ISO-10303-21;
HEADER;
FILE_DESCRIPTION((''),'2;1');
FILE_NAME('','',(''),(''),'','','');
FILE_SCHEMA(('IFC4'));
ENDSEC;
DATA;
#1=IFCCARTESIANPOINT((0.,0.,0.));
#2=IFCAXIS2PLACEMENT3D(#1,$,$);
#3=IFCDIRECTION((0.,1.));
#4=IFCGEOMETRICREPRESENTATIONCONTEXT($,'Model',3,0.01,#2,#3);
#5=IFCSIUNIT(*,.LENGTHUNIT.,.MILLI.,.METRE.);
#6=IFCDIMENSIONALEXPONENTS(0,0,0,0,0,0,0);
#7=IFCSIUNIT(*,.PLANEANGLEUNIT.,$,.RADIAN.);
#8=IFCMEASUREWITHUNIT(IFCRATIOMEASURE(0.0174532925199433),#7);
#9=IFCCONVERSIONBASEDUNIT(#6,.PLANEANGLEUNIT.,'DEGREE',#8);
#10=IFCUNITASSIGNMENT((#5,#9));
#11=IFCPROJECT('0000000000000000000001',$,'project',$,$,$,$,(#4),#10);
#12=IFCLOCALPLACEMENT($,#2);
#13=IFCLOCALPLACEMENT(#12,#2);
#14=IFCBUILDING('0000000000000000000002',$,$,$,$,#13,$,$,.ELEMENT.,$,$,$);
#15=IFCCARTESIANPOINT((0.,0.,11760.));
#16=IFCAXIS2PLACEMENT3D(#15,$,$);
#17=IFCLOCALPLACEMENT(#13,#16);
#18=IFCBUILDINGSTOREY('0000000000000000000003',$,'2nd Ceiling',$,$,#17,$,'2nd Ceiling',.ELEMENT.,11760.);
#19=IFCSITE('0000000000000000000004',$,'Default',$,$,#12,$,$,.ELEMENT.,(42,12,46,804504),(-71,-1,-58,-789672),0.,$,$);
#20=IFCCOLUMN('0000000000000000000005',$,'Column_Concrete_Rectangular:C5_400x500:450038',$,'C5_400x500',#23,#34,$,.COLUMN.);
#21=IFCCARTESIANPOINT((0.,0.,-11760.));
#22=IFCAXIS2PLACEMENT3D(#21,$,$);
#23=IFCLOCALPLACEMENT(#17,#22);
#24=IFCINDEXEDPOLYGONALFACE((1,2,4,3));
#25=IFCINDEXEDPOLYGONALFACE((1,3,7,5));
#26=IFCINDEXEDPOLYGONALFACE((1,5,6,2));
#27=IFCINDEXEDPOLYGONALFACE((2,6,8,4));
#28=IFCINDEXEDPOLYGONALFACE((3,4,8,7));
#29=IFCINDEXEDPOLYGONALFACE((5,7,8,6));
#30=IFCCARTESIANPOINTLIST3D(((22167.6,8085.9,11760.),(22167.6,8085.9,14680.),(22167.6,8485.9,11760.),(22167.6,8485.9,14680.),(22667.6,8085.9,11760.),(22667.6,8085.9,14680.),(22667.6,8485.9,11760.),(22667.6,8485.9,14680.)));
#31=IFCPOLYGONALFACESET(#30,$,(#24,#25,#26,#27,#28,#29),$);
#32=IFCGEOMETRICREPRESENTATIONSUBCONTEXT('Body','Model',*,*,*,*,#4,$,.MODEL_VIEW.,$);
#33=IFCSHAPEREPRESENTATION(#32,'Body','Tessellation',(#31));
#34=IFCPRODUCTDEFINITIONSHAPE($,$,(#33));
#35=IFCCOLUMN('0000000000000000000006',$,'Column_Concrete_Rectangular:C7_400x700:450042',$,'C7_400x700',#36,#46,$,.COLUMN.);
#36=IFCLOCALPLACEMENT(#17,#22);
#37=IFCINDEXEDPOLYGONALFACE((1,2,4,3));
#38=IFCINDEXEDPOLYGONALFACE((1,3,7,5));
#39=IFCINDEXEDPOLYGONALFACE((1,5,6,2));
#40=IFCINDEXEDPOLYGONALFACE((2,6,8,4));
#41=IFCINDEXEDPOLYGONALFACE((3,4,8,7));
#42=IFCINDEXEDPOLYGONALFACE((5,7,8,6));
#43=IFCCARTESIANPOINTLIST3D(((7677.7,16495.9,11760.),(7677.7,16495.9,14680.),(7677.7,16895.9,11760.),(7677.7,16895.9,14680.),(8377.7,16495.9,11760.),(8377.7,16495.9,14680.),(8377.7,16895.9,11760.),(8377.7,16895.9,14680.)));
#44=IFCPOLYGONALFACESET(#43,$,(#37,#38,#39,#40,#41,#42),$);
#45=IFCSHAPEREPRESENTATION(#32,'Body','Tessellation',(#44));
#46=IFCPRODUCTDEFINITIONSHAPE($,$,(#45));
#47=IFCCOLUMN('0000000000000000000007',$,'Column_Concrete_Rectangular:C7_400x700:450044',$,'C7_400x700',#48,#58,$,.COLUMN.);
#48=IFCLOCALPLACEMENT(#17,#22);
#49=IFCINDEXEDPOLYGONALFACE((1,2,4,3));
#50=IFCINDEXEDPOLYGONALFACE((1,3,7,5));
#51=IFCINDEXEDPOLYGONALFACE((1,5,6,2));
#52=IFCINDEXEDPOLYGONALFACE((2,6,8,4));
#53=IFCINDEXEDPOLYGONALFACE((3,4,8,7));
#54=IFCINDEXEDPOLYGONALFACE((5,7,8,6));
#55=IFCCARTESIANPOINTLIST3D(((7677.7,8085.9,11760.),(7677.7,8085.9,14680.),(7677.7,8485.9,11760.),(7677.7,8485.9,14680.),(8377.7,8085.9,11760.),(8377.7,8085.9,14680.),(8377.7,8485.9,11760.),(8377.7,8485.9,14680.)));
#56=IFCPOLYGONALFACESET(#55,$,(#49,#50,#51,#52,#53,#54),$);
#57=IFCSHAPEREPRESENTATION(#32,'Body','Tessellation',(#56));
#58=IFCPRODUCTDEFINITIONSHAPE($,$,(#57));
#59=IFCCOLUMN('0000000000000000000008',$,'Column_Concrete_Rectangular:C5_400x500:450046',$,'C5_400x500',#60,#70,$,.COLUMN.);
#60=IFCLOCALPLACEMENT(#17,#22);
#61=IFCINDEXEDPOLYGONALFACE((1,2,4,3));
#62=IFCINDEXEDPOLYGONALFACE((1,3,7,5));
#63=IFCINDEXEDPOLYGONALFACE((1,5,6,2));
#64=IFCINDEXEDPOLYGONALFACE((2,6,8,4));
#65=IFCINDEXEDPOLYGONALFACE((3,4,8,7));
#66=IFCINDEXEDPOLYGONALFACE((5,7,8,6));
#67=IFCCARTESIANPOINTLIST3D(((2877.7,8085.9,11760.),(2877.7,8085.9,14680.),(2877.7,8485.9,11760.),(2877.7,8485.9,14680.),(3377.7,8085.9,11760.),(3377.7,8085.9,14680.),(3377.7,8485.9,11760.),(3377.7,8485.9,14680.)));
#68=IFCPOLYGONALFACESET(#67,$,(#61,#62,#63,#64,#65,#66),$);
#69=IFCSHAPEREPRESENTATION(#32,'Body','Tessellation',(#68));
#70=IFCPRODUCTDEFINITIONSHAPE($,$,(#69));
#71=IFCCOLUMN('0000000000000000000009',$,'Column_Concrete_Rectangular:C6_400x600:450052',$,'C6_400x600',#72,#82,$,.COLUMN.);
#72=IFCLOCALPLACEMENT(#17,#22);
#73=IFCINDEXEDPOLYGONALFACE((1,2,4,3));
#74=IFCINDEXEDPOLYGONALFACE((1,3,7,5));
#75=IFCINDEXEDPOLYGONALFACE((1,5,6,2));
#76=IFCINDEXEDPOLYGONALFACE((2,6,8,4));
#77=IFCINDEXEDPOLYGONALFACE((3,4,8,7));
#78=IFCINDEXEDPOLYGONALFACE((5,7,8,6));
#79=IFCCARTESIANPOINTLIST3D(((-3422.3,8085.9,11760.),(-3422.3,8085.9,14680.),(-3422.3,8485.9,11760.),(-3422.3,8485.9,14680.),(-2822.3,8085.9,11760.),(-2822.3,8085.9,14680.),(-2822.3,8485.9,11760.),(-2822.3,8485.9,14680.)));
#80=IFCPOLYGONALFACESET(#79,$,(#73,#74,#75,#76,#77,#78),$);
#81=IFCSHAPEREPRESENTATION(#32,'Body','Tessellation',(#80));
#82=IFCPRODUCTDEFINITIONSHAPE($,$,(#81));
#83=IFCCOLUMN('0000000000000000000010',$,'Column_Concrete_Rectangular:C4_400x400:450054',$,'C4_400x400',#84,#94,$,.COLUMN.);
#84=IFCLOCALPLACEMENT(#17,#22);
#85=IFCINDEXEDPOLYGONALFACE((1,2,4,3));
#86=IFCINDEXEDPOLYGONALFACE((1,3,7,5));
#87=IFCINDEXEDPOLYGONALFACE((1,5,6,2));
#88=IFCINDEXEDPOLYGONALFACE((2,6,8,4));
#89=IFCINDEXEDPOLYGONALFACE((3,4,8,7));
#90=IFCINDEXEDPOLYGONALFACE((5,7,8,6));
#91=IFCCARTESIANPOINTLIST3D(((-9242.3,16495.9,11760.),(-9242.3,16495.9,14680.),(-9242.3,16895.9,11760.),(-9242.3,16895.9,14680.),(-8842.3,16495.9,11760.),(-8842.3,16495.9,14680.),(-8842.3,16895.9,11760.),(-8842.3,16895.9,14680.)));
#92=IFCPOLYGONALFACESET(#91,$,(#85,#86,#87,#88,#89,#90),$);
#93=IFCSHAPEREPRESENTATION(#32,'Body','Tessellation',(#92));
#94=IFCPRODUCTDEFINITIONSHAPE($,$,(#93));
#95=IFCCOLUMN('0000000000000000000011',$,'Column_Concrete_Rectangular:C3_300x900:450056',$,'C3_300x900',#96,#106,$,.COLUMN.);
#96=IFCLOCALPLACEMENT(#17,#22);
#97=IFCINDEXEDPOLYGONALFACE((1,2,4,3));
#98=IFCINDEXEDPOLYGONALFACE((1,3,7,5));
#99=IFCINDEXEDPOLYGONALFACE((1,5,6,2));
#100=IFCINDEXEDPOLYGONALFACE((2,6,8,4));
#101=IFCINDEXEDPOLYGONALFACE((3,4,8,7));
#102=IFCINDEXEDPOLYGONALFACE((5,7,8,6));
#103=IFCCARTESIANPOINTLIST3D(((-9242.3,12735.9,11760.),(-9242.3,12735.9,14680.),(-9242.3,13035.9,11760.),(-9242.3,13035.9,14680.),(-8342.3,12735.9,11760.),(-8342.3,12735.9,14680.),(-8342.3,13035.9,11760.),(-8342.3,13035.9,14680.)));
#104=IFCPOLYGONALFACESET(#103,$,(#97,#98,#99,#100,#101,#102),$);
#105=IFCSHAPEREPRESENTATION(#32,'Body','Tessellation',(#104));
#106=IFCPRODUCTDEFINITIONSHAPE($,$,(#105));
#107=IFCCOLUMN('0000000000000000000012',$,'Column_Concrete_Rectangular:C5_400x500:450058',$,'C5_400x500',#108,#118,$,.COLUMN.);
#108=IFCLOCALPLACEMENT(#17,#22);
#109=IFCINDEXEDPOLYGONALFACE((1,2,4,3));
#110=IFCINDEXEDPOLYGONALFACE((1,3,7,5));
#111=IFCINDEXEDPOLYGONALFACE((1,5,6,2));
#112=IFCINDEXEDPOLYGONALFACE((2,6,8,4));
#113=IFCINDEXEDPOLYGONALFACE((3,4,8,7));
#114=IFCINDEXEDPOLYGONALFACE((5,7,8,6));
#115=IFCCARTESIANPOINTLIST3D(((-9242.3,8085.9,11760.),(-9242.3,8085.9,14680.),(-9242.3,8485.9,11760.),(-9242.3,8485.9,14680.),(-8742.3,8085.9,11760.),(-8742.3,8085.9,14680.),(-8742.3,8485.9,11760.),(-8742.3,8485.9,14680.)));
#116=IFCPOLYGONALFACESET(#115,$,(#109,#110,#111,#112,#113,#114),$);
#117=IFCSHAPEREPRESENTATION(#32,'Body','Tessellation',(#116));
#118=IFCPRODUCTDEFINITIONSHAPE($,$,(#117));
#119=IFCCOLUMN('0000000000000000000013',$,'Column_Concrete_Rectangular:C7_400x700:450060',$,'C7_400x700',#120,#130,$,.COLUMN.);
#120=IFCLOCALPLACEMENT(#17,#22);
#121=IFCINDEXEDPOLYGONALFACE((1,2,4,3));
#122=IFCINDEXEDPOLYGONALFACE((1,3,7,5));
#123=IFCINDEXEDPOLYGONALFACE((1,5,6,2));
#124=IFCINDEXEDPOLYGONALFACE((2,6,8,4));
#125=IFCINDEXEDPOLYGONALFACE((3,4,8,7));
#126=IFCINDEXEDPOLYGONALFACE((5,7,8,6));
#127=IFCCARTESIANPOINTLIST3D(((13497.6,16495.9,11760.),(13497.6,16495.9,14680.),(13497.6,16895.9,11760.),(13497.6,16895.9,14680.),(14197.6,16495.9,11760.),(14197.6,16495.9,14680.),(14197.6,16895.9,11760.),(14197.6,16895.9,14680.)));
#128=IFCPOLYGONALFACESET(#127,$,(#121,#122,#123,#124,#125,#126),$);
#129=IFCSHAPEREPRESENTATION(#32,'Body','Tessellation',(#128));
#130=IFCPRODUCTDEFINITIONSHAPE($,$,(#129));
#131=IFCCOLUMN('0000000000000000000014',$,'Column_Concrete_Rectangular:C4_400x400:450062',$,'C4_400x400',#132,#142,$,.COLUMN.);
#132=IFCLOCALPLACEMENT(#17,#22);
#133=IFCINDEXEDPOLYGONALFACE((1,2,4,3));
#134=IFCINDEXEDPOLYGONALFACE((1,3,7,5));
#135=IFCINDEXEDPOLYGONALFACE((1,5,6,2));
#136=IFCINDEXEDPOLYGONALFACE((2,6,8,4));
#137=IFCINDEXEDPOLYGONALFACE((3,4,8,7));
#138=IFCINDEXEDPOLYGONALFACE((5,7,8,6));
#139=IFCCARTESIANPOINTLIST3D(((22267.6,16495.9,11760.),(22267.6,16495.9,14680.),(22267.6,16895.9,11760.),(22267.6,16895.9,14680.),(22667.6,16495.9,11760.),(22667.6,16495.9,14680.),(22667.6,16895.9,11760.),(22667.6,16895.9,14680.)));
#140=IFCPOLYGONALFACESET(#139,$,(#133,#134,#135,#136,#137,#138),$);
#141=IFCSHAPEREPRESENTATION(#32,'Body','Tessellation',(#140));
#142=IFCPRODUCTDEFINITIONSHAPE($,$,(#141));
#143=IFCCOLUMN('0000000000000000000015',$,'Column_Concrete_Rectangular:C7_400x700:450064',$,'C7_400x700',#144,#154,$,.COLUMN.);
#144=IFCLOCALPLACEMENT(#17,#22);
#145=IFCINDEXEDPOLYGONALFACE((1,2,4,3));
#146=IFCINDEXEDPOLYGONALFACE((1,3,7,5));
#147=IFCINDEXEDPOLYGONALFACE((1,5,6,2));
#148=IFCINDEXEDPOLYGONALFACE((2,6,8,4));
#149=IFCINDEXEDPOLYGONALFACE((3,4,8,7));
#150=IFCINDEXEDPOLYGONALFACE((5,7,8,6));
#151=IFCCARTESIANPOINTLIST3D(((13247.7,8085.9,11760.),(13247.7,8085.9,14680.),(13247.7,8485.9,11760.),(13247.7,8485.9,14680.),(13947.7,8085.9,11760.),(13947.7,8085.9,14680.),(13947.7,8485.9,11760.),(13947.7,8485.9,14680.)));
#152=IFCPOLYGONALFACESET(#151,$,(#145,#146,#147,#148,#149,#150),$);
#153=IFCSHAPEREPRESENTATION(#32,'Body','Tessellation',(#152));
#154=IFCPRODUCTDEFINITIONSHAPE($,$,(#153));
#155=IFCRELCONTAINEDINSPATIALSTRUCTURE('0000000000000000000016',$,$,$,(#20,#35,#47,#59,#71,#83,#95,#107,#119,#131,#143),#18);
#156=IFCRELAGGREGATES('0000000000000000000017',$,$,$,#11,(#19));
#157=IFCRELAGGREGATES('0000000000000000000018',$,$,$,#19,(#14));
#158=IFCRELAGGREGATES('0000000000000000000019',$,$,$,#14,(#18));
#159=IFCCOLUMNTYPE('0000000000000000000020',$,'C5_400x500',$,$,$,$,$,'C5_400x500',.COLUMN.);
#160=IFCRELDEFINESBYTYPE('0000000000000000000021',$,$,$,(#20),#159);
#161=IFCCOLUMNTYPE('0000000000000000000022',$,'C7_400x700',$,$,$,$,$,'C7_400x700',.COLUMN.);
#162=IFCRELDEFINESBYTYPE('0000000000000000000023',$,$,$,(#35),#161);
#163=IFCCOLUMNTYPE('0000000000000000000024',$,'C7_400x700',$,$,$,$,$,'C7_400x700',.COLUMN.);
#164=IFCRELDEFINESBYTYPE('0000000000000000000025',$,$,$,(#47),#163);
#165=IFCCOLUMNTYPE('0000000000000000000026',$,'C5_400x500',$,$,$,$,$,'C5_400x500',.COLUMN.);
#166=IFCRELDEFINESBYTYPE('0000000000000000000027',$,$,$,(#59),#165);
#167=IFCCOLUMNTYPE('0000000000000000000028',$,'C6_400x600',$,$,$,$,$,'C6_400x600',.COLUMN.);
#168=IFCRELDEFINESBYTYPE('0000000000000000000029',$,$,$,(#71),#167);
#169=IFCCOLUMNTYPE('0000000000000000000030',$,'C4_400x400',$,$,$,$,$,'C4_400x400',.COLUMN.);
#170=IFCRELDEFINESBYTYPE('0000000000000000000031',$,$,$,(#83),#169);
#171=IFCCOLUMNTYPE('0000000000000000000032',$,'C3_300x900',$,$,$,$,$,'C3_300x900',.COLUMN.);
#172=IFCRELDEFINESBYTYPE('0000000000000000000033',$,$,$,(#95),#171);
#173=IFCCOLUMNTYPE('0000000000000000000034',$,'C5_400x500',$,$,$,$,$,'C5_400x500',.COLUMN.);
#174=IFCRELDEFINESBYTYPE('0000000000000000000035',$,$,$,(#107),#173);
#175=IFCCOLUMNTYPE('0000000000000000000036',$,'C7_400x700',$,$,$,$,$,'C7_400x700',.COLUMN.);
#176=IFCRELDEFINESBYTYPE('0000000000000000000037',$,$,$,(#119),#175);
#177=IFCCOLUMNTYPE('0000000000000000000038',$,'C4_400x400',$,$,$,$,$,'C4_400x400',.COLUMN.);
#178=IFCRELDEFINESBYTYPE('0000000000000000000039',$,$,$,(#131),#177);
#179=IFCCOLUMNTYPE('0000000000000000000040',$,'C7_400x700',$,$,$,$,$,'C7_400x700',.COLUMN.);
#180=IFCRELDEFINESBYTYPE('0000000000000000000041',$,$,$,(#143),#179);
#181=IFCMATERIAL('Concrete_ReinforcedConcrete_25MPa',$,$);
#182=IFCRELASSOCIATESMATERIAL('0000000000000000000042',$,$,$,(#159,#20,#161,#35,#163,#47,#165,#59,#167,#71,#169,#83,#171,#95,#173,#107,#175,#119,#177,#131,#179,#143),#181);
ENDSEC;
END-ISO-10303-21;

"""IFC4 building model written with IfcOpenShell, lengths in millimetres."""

from ifc_helpers import new_model, entity, si_unit, converted_unit, direction, frame, frame_2d, origin, origin_2d_with_axis, place, context, subcontext, project, spatial, rectangle, extrude, source, transform, mapped, material, type_object, type_shapes, element, save


model = new_model("IFC4")

# Units and contexts
model_context = context("Model", 3, precision=0.01, world=origin(), true_north=direction((0.0, 1.0)))
body_context = subcontext(model_context, "Body", "Model", "MODEL_VIEW")
ifc_project = project(units=[si_unit("LENGTHUNIT", "METRE", prefix="MILLI"), converted_unit("PLANEANGLEUNIT", "DEGREE", entity("IfcRatioMeasure", 0.0174532925199433), si_unit("PLANEANGLEUNIT", "RADIAN"), dimensions=[0, 0, 0, 0, 0, 0, 0])], contexts=[model_context])

# Site, building, storey
site_placement = place(None, origin())
site = spatial("IfcSite", under=ifc_project, at=site_placement, Name="Default", CompositionType="ELEMENT", RefLatitude=(42, 12, 46, 804504), RefLongitude=(-71, -1, -58, -789672), RefElevation=0.0)
building_placement = place(site_placement, origin())
building = spatial("IfcBuilding", under=site, at=building_placement, CompositionType="ELEMENT")
storey_placement = place(building_placement, frame((0.0, 0.0, 11760.0)))
storey = spatial("IfcBuildingStorey", under=building, at=storey_placement, Name="2nd Ceiling", LongName="2nd Ceiling", CompositionType="ELEMENT", Elevation=11760.0)

# Columns
ifc_material = material(Name="Concrete_ReinforcedConcrete_25MPa")
column_type_1 = type_object("IfcColumnType", Name="C5_400x500", ElementType="C5_400x500", PredefinedType="COLUMN", material=ifc_material)
shared_shape_1 = source(origin(), body_context, "Body", "SweptSolid", [
    extrude(rectangle(XDim=400.0, YDim=500.0, at=frame_2d((0.0, 0.0), x_axis=(1.0, 0.0))), frame((22417.6, 8285.9, 11760.0), z_axis=(0.0, 0.0, 1.0), x_axis=(0.0, -1.0, 0.0)), (0.0, 0.0, 1.0), 2920.0),
])
type_shapes(column_type_1, [shared_shape_1])
column_1_placement = place(storey_placement, frame((0.0, 0.0, -11760.0)))
element("IfcColumn", 1, at=column_1_placement, inside=storey, type_object=column_type_1, material=ifc_material, Name="Column_Concrete_Rectangular:C5_400x500:450038", ObjectType="C5_400x500", PredefinedType="COLUMN", context=body_context, shape_type="MappedRepresentation", body=[
    mapped(shared_shape_1, transform((0.0, 0.0, 0.0), scale=1.0)),
])
column_type_2 = type_object("IfcColumnType", Name="C7_400x700", ElementType="C7_400x700", PredefinedType="COLUMN", material=ifc_material)
shared_shape_2 = source(origin(), body_context, "Body", "SweptSolid", [
    extrude(rectangle(XDim=400.0, YDim=700.0, at=frame_2d((0.0, 0.0), x_axis=(1.0, 0.0))), frame((8027.7, 16695.9, 11760.0), z_axis=(0.0, 0.0, 1.0), x_axis=(0.0, -1.0, 0.0)), (0.0, 0.0, 1.0), 2920.0),
])
type_shapes(column_type_2, [shared_shape_2])
column_2_placement = place(storey_placement, frame((0.0, 0.0, -11760.0)))
element("IfcColumn", 2, at=column_2_placement, inside=storey, type_object=column_type_2, material=ifc_material, Name="Column_Concrete_Rectangular:C7_400x700:450042", ObjectType="C7_400x700", PredefinedType="COLUMN", context=body_context, shape_type="MappedRepresentation", body=[
    mapped(shared_shape_2, transform((0.0, 0.0, 0.0), scale=1.0)),
])
column_type_3 = type_object("IfcColumnType", Name="C7_400x700", ElementType="C7_400x700", PredefinedType="COLUMN", material=ifc_material)
shared_shape_3 = source(origin(), body_context, "Body", "SweptSolid", [
    extrude(rectangle(XDim=400.0, YDim=700.0, at=origin_2d_with_axis()), frame((8027.7, 8285.9, 11760.0), z_axis=(0.0, 0.0, 1.0), x_axis=(0.0, -1.0, 0.0)), (0.0, 0.0, 1.0), 2920.0),
])
type_shapes(column_type_3, [shared_shape_3])
column_3_placement = place(storey_placement, frame((0.0, 0.0, -11760.0)))
element("IfcColumn", 3, at=column_3_placement, inside=storey, type_object=column_type_3, material=ifc_material, Name="Column_Concrete_Rectangular:C7_400x700:450044", ObjectType="C7_400x700", PredefinedType="COLUMN", context=body_context, shape_type="MappedRepresentation", body=[
    mapped(shared_shape_3, transform((0.0, 0.0, 0.0), scale=1.0)),
])
column_type_4 = type_object("IfcColumnType", Name="C5_400x500", ElementType="C5_400x500", PredefinedType="COLUMN", material=ifc_material)
shared_shape_4 = source(origin(), body_context, "Body", "SweptSolid", [
    extrude(rectangle(XDim=400.0, YDim=500.0, at=origin_2d_with_axis()), frame((3127.7, 8285.9, 11760.0), z_axis=(0.0, 0.0, 1.0), x_axis=(0.0, -1.0, 0.0)), (0.0, 0.0, 1.0), 2920.0),
])
type_shapes(column_type_4, [shared_shape_4])
column_4_placement = place(storey_placement, frame((0.0, 0.0, -11760.0)))
element("IfcColumn", 4, at=column_4_placement, inside=storey, type_object=column_type_4, material=ifc_material, Name="Column_Concrete_Rectangular:C5_400x500:450046", ObjectType="C5_400x500", PredefinedType="COLUMN", context=body_context, shape_type="MappedRepresentation", body=[
    mapped(shared_shape_4, transform((0.0, 0.0, 0.0), scale=1.0)),
])
column_type_5 = type_object("IfcColumnType", Name="C6_400x600", ElementType="C6_400x600", PredefinedType="COLUMN", material=ifc_material)
shared_shape_5 = source(origin(), body_context, "Body", "SweptSolid", [
    extrude(rectangle(XDim=400.0, YDim=600.0, at=origin_2d_with_axis()), frame((-3122.3, 8285.9, 11760.0), z_axis=(0.0, 0.0, 1.0), x_axis=(0.0, -1.0, 0.0)), (0.0, 0.0, 1.0), 2920.0),
])
type_shapes(column_type_5, [shared_shape_5])
column_5_placement = place(storey_placement, frame((0.0, 0.0, -11760.0)))
element("IfcColumn", 5, at=column_5_placement, inside=storey, type_object=column_type_5, material=ifc_material, Name="Column_Concrete_Rectangular:C6_400x600:450052", ObjectType="C6_400x600", PredefinedType="COLUMN", context=body_context, shape_type="MappedRepresentation", body=[
    mapped(shared_shape_5, transform((0.0, 0.0, 0.0), scale=1.0)),
])
column_type_6 = type_object("IfcColumnType", Name="C4_400x400", ElementType="C4_400x400", PredefinedType="COLUMN", material=ifc_material)
shared_shape_6 = source(origin(), body_context, "Body", "SweptSolid", [
    extrude(rectangle(XDim=400.0, YDim=400.0, at=origin_2d_with_axis()), frame((-9042.3, 16695.9, 11760.0), z_axis=(0.0, 0.0, 1.0), x_axis=(0.0, -1.0, 0.0)), (0.0, 0.0, 1.0), 2920.0),
])
type_shapes(column_type_6, [shared_shape_6])
column_6_placement = place(storey_placement, frame((0.0, 0.0, -11760.0)))
element("IfcColumn", 6, at=column_6_placement, inside=storey, type_object=column_type_6, material=ifc_material, Name="Column_Concrete_Rectangular:C4_400x400:450054", ObjectType="C4_400x400", PredefinedType="COLUMN", context=body_context, shape_type="MappedRepresentation", body=[
    mapped(shared_shape_6, transform((0.0, 0.0, 0.0), scale=1.0)),
])
column_type_7 = type_object("IfcColumnType", Name="C3_300x900", ElementType="C3_300x900", PredefinedType="COLUMN", material=ifc_material)
shared_shape_7 = source(origin(), body_context, "Body", "SweptSolid", [
    extrude(rectangle(XDim=300.0, YDim=900.0, at=frame_2d((0.0, 0.0), x_axis=(1.0, 0.0))), frame((-8792.3, 12885.9, 11760.0), z_axis=(0.0, 0.0, 1.0), x_axis=(0.0, -1.0, 0.0)), (0.0, 0.0, 1.0), 2920.0),
])
type_shapes(column_type_7, [shared_shape_7])
column_7_placement = place(storey_placement, frame((0.0, 0.0, -11760.0)))
element("IfcColumn", 7, at=column_7_placement, inside=storey, type_object=column_type_7, material=ifc_material, Name="Column_Concrete_Rectangular:C3_300x900:450056", ObjectType="C3_300x900", PredefinedType="COLUMN", context=body_context, shape_type="MappedRepresentation", body=[
    mapped(shared_shape_7, transform((0.0, 0.0, 0.0), scale=1.0)),
])
column_type_8 = type_object("IfcColumnType", Name="C5_400x500", ElementType="C5_400x500", PredefinedType="COLUMN", material=ifc_material)
shared_shape_8 = source(origin(), body_context, "Body", "SweptSolid", [
    extrude(rectangle(XDim=400.0, YDim=500.0, at=frame_2d((0.0, 0.0), x_axis=(1.0, 0.0))), frame((-8992.3, 8285.9, 11760.0), z_axis=(0.0, 0.0, 1.0), x_axis=(0.0, -1.0, 0.0)), (0.0, 0.0, 1.0), 2920.0),
])
type_shapes(column_type_8, [shared_shape_8])
column_8_placement = place(storey_placement, frame((0.0, 0.0, -11760.0)))
element("IfcColumn", 8, at=column_8_placement, inside=storey, type_object=column_type_8, material=ifc_material, Name="Column_Concrete_Rectangular:C5_400x500:450058", ObjectType="C5_400x500", PredefinedType="COLUMN", context=body_context, shape_type="MappedRepresentation", body=[
    mapped(shared_shape_8, transform((0.0, 0.0, 0.0), scale=1.0)),
])
column_type_9 = type_object("IfcColumnType", Name="C7_400x700", ElementType="C7_400x700", PredefinedType="COLUMN", material=ifc_material)
shared_shape_9 = source(origin(), body_context, "Body", "SweptSolid", [
    extrude(rectangle(XDim=400.0, YDim=700.0, at=frame_2d((0.0, 0.0), x_axis=(1.0, 0.0))), frame((13847.6, 16695.9, 11760.0), z_axis=(0.0, 0.0, 1.0), x_axis=(0.0, -1.0, 0.0)), (0.0, 0.0, 1.0), 2920.0),
])
type_shapes(column_type_9, [shared_shape_9])
column_9_placement = place(storey_placement, frame((0.0, 0.0, -11760.0)))
element("IfcColumn", 9, at=column_9_placement, inside=storey, type_object=column_type_9, material=ifc_material, Name="Column_Concrete_Rectangular:C7_400x700:450060", ObjectType="C7_400x700", PredefinedType="COLUMN", context=body_context, shape_type="MappedRepresentation", body=[
    mapped(shared_shape_9, transform((0.0, 0.0, 0.0), scale=1.0)),
])
column_type_10 = type_object("IfcColumnType", Name="C4_400x400", ElementType="C4_400x400", PredefinedType="COLUMN", material=ifc_material)
shared_shape_10 = source(origin(), body_context, "Body", "SweptSolid", [
    extrude(rectangle(XDim=400.0, YDim=400.0, at=frame_2d((0.0, 0.0), x_axis=(1.0, 0.0))), frame((22467.6, 16695.9, 11760.0), z_axis=(0.0, 0.0, 1.0), x_axis=(0.0, -1.0, 0.0)), (0.0, 0.0, 1.0), 2920.0),
])
type_shapes(column_type_10, [shared_shape_10])
column_10_placement = place(storey_placement, frame((0.0, 0.0, -11760.0)))
element("IfcColumn", 10, at=column_10_placement, inside=storey, type_object=column_type_10, material=ifc_material, Name="Column_Concrete_Rectangular:C4_400x400:450062", ObjectType="C4_400x400", PredefinedType="COLUMN", context=body_context, shape_type="MappedRepresentation", body=[
    mapped(shared_shape_10, transform((0.0, 0.0, 0.0), scale=1.0)),
])
column_type_11 = type_object("IfcColumnType", Name="C7_400x700", ElementType="C7_400x700", PredefinedType="COLUMN", material=ifc_material)
shared_shape_11 = source(origin(), body_context, "Body", "SweptSolid", [
    extrude(rectangle(XDim=400.0, YDim=700.0, at=frame_2d((0.0, 0.0), x_axis=(1.0, 0.0))), frame((13597.7, 8285.9, 11760.0), z_axis=(0.0, 0.0, 1.0), x_axis=(0.0, -1.0, 0.0)), (0.0, 0.0, 1.0), 2920.0),
])
type_shapes(column_type_11, [shared_shape_11])
column_11_placement = place(storey_placement, frame((0.0, 0.0, -11760.0)))
element("IfcColumn", 11, at=column_11_placement, inside=storey, type_object=column_type_11, material=ifc_material, Name="Column_Concrete_Rectangular:C7_400x700:450064", ObjectType="C7_400x700", PredefinedType="COLUMN", context=body_context, shape_type="MappedRepresentation", body=[
    mapped(shared_shape_11, transform((0.0, 0.0, 0.0), scale=1.0)),
])

save(model, "model.ifc")
